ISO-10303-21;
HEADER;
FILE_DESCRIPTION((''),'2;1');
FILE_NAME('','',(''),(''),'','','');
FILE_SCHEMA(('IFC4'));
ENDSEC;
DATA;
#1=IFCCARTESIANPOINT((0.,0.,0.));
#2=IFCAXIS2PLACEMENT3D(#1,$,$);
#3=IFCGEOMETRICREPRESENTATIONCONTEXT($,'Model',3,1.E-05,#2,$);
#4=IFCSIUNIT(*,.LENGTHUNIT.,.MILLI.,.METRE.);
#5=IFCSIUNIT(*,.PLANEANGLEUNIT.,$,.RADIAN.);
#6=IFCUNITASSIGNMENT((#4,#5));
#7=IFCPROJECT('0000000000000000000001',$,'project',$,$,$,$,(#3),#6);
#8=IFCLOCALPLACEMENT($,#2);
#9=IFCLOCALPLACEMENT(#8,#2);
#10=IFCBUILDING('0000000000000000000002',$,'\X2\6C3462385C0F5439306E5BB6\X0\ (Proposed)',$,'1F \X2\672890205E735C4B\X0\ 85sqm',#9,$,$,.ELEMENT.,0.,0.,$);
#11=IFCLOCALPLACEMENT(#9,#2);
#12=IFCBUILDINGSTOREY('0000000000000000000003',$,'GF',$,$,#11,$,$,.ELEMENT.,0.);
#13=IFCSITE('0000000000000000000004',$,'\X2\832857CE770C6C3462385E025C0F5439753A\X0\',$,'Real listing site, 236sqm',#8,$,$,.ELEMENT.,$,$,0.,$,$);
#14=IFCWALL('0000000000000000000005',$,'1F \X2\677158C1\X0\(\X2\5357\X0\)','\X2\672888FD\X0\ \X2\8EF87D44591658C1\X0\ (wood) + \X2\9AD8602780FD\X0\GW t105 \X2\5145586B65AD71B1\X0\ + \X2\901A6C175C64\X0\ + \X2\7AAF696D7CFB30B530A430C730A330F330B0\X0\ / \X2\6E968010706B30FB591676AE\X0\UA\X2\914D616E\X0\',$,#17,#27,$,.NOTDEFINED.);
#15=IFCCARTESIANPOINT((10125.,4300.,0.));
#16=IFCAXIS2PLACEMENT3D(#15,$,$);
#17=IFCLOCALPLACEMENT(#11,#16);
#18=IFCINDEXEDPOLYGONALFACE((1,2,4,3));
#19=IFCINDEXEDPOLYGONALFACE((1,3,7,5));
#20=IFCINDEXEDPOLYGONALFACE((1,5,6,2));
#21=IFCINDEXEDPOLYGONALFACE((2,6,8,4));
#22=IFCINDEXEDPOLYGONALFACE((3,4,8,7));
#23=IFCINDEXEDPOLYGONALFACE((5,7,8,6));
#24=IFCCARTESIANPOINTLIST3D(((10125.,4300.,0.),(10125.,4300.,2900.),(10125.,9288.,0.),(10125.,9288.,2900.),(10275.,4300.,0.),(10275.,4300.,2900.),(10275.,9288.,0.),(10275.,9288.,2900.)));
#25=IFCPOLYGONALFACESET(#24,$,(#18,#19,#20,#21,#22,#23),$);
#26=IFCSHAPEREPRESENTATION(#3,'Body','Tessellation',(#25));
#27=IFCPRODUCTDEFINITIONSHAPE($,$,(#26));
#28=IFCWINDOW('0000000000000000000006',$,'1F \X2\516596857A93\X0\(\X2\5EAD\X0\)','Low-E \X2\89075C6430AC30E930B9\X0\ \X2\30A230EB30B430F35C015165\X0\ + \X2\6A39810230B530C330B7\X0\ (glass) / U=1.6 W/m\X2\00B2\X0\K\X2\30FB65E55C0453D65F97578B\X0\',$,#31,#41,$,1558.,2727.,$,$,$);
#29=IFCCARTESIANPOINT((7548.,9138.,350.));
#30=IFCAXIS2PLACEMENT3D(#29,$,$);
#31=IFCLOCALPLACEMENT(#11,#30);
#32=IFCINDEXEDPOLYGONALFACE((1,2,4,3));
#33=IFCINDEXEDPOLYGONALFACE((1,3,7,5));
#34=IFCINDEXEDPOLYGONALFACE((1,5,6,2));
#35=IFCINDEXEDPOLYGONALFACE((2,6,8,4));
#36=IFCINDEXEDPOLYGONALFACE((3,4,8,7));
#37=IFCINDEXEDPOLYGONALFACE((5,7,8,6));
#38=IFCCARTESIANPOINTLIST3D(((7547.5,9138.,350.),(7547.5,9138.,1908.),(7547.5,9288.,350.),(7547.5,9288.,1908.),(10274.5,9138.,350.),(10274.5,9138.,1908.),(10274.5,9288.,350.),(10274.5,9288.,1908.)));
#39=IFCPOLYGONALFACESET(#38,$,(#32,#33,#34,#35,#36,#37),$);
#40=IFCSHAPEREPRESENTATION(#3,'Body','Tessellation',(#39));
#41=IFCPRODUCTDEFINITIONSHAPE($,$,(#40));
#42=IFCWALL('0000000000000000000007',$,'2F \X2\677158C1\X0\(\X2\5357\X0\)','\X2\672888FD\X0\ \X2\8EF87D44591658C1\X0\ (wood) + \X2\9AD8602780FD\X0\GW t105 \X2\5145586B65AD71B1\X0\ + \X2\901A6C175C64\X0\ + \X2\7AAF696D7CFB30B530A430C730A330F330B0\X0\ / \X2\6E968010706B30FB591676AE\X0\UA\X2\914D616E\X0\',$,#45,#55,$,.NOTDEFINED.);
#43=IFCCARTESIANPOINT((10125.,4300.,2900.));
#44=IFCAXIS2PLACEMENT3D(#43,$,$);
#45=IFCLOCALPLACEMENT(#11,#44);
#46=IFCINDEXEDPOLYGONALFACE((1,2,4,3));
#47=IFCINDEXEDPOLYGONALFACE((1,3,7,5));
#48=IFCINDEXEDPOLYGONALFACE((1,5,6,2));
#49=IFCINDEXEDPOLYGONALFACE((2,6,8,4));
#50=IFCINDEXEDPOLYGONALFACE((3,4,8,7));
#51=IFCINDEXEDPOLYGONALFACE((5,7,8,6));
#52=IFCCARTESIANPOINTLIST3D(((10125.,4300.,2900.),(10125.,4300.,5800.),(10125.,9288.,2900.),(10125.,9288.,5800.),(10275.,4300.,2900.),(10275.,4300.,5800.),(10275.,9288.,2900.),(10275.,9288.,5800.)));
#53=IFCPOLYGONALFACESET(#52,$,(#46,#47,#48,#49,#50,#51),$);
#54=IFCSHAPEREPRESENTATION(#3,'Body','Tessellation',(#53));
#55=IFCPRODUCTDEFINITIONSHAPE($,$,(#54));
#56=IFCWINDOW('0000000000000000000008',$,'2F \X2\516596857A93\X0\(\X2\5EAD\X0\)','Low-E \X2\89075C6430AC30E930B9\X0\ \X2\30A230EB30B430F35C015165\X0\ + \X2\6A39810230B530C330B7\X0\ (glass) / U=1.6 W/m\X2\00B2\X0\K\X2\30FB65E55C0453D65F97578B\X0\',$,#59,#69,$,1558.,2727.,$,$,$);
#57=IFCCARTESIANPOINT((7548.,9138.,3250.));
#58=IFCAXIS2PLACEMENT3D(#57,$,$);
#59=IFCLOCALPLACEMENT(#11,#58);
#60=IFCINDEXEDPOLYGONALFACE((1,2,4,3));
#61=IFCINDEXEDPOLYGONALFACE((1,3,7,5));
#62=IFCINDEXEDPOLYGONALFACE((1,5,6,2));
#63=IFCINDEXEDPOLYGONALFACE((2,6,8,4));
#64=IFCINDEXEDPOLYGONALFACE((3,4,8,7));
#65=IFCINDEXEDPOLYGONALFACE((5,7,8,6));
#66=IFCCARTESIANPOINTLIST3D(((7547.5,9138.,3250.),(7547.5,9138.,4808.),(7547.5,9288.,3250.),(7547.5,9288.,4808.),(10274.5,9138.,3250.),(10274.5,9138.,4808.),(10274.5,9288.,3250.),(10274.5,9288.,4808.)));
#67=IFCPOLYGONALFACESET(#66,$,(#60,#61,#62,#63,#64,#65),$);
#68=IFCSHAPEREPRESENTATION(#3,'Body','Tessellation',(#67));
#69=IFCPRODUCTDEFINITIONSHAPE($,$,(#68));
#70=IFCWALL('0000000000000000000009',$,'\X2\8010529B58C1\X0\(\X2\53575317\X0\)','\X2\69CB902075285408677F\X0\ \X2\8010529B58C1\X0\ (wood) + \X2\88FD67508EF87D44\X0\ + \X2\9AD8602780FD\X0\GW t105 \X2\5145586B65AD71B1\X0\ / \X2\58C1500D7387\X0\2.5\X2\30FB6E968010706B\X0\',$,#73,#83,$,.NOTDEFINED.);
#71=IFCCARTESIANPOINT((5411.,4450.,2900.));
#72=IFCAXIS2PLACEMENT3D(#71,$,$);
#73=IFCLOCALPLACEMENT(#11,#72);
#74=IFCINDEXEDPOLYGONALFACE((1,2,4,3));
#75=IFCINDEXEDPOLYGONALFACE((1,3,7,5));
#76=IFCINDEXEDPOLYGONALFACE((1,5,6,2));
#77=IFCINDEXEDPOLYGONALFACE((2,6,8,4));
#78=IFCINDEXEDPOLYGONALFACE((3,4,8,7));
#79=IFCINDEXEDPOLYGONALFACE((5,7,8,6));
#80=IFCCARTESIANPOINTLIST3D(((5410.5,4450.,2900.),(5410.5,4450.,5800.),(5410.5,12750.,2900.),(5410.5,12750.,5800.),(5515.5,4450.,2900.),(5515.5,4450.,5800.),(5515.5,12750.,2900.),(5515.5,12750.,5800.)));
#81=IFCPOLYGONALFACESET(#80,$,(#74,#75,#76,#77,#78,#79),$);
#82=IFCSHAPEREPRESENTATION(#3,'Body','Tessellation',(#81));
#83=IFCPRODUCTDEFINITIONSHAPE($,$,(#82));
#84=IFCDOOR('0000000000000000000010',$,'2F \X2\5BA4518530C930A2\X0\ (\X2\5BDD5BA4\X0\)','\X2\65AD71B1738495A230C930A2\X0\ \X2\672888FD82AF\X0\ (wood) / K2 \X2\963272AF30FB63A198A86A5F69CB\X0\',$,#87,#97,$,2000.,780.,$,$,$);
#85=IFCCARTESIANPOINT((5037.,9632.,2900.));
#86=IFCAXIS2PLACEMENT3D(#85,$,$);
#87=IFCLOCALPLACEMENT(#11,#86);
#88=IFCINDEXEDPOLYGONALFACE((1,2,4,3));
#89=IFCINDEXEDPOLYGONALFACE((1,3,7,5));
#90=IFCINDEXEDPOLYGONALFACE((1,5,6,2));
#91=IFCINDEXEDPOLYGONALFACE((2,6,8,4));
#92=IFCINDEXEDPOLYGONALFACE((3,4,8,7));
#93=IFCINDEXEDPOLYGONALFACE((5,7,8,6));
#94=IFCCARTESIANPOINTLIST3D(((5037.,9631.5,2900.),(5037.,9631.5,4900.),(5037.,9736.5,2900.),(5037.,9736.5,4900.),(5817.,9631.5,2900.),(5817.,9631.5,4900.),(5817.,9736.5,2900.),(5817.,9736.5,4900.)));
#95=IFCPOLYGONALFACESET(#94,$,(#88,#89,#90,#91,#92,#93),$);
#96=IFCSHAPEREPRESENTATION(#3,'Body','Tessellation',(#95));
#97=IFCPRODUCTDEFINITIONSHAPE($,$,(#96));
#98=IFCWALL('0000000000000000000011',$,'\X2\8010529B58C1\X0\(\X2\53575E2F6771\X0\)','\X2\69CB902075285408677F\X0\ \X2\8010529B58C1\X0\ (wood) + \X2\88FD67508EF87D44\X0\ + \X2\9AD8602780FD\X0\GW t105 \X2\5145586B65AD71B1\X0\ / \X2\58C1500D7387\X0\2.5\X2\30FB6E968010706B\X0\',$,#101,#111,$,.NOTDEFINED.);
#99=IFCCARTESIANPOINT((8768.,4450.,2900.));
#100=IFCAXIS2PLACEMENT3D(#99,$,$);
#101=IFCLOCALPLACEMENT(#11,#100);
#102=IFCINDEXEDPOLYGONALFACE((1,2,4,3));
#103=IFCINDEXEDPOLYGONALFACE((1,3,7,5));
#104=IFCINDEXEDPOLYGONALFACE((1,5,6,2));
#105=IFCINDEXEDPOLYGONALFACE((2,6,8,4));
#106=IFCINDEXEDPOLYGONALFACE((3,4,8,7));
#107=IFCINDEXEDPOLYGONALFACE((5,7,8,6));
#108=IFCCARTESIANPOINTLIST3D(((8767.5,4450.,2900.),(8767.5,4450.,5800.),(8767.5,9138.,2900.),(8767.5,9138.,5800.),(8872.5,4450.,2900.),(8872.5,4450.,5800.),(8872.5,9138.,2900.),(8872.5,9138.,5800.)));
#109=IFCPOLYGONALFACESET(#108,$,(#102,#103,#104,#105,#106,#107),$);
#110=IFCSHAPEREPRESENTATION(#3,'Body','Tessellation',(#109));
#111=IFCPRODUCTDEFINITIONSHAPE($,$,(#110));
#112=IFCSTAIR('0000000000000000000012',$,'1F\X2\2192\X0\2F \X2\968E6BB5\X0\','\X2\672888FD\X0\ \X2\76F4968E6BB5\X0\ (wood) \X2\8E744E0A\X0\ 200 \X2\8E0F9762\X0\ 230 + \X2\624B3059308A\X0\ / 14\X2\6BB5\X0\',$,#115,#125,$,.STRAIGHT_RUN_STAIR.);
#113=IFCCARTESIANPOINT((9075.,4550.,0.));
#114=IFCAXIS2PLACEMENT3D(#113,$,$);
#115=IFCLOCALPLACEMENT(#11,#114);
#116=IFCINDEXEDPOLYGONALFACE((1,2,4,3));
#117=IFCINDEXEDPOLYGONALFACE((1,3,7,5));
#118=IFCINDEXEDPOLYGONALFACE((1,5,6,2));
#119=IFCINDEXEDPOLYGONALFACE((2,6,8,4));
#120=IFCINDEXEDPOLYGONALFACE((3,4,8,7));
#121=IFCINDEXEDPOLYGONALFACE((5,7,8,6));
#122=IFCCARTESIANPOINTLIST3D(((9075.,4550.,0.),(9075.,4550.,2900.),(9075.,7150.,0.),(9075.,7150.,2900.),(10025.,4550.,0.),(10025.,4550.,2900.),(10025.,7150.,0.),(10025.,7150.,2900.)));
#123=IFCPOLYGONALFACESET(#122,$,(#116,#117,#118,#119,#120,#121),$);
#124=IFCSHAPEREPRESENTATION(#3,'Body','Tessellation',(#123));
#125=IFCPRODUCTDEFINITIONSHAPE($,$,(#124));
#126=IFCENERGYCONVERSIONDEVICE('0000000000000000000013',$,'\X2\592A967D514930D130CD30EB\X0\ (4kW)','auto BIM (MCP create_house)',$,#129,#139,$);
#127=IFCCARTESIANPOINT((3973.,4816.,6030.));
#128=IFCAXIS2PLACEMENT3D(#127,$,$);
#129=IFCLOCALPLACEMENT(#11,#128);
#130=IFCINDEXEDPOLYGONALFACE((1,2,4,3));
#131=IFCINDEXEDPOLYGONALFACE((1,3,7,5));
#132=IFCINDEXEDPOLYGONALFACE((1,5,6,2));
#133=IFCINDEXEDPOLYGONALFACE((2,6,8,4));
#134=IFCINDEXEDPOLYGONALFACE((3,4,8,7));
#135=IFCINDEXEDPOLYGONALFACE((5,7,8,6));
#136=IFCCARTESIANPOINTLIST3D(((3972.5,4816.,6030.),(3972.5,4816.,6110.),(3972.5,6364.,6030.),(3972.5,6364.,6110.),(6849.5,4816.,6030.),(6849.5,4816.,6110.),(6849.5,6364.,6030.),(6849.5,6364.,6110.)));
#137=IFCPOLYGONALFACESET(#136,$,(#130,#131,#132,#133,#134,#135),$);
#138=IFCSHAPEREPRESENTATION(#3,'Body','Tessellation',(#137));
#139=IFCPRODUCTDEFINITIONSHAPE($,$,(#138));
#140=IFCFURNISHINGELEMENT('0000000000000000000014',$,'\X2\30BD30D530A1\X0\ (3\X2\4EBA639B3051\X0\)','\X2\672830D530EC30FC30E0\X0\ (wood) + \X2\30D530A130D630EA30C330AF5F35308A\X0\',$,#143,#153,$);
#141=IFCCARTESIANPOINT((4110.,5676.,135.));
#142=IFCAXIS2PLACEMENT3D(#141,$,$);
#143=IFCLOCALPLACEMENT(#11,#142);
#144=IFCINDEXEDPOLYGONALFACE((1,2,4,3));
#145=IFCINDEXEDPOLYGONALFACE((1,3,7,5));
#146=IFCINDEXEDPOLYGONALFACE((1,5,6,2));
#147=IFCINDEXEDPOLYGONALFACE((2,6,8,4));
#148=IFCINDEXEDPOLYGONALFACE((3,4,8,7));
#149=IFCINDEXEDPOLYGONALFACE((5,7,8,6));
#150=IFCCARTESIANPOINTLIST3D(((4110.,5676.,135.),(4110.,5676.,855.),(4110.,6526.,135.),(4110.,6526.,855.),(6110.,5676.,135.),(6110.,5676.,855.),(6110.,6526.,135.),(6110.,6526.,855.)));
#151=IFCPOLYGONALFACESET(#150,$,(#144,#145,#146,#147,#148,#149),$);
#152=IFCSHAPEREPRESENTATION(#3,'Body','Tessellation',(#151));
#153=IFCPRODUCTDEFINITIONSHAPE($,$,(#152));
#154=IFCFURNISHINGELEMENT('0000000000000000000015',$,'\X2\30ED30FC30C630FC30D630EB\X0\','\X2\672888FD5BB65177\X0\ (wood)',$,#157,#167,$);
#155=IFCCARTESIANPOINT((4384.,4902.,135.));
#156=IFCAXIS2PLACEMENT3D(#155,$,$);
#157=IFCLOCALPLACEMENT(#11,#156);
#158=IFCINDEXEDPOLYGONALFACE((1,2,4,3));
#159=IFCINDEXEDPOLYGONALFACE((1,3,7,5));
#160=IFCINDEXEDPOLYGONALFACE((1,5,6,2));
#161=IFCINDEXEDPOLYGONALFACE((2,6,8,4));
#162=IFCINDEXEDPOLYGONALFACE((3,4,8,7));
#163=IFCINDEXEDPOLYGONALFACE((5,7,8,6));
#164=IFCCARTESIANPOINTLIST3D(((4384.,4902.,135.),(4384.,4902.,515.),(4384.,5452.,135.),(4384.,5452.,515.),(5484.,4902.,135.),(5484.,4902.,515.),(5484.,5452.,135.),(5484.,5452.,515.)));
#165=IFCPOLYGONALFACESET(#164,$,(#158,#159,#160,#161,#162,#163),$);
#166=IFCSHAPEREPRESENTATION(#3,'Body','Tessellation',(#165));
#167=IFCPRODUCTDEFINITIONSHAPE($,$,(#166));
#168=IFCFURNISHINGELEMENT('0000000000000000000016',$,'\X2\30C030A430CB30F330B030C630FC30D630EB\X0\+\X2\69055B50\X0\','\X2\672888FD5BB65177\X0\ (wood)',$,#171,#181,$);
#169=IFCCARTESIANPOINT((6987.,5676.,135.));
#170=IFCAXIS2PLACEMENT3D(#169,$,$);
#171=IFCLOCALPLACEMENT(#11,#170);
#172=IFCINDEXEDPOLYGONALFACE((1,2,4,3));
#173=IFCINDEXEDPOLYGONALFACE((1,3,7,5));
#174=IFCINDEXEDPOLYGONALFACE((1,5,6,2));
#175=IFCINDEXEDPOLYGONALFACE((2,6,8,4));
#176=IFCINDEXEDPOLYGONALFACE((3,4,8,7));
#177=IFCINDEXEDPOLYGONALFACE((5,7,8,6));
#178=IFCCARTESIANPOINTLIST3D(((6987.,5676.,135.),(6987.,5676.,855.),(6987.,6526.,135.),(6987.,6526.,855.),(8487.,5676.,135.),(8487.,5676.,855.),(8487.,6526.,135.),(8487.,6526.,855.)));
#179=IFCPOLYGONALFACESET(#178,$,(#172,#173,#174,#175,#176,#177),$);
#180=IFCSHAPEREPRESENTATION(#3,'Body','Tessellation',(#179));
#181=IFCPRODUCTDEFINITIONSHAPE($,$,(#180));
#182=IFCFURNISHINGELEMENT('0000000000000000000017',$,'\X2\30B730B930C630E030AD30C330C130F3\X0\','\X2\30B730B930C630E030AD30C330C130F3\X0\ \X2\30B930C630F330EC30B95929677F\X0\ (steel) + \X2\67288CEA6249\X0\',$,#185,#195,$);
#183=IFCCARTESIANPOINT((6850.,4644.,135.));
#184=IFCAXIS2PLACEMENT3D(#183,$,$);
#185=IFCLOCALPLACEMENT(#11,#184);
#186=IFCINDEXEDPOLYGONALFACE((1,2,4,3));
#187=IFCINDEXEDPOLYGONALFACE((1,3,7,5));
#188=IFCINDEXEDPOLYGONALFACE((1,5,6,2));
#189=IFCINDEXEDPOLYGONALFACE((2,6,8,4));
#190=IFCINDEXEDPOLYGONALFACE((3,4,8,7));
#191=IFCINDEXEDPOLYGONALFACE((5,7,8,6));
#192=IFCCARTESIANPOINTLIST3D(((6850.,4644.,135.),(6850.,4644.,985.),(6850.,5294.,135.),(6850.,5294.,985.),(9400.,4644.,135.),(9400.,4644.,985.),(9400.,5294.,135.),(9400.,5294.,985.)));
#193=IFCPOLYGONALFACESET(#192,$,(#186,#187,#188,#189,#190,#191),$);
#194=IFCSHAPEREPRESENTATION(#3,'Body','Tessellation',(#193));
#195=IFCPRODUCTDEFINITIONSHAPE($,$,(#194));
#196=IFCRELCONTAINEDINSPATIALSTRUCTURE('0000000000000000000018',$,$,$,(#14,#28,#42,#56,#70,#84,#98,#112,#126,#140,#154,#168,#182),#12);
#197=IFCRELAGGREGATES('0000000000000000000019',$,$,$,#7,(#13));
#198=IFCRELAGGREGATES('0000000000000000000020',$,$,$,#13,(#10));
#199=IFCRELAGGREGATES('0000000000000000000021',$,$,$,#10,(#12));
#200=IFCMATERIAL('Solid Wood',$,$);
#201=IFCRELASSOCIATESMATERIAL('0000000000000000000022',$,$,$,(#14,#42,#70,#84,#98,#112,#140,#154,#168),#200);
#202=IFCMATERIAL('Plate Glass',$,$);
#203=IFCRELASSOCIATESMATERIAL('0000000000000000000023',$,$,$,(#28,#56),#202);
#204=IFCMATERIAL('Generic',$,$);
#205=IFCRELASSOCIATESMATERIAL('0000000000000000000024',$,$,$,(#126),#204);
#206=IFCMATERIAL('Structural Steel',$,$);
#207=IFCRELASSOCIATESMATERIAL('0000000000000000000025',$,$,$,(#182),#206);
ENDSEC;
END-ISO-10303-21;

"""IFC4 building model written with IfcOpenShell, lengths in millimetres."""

from ifc_helpers import new_model, si_unit, frame, frame_2d, origin, place, context, project, spatial, rectangle, extrude, material, element, fill, save


model = new_model("IFC4")

# Units and contexts
model_context = context("Model", 3, precision=1e-05, world=origin())
ifc_project = project(units=[si_unit("LENGTHUNIT", "METRE", prefix="MILLI"), si_unit("PLANEANGLEUNIT", "RADIAN")], contexts=[model_context])

# Site, building, storey
site_placement = place(None, origin())
site = spatial("IfcSite", under=ifc_project, at=site_placement, Name="茨城県水戸市小吹町", ObjectType="Real listing site, 236sqm", CompositionType="ELEMENT", RefElevation=0.0)
building_placement = place(site_placement, origin())
building = spatial("IfcBuilding", under=site, at=building_placement, Name="水戸小吹の家 (Proposed)", ObjectType="1F 木造平屋 85sqm", CompositionType="ELEMENT", ElevationOfRefHeight=0.0, ElevationOfTerrain=0.0)
storey_placement = place(building_placement, origin())
storey = spatial("IfcBuildingStorey", under=building, at=storey_placement, Name="GF", CompositionType="ELEMENT", Elevation=0.0)

# Wall, opening, window
ifc_material_1 = material(Name="Solid Wood")
wall_1_placement = place(storey_placement, frame((10125.0, 4300.0, 0.0)))
wall_1 = element("IfcWall", 1, at=wall_1_placement, inside=storey, material=ifc_material_1, Name="1F 東壁(南)", Description="木製 軸組外壁 (wood) + 高性能GW t105 充填断熱 + 通気層 + 窯業系サイディング / 準耐火・外皮UA配慮", PredefinedType="NOTDEFINED", context=model_context, shape_type="SweptSolid", body=[
    extrude(rectangle(XDim=150.0, YDim=4988.0, at=frame_2d((75.0, 2494.0))), frame((10125.0, 4300.0, 0.0)), (0.0, 0.0, 1.0), 2900.0),
])
opening_1_placement = place(storey_placement, frame((7548.0, 9138.0, 350.0)))
opening_1 = element("IfcOpeningElement", 2, at=opening_1_placement, cuts=wall_1, PredefinedType="NOTDEFINED", context=model_context, shape_type="SweptSolid", body=[
    extrude(rectangle(XDim=2727.0, YDim=150.0, at=frame_2d((1363.0, 75.0))), frame((7548.0, 9138.0, 350.0)), (0.0, 0.0, 1.0), 1558.0),
])
ifc_material_2 = material(Name="Plate Glass")
window_1_placement = place(storey_placement, frame((7548.0, 9138.0, 350.0)))
window_1 = element("IfcWindow", 3, at=window_1_placement, inside=storey, material=ifc_material_2, Name="1F 入隅窓(庭)", Description="Low-E 複層ガラス アルゴン封入 + 樹脂サッシ (glass) / U=1.6 W/m²K・日射取得型", OverallHeight=1558.0, OverallWidth=2727.0, context=model_context, shape_type="SweptSolid", body=[
    extrude(rectangle(XDim=2727.0, YDim=150.0, at=frame_2d((1363.0, 75.0))), frame((7548.0, 9138.0, 350.0)), (0.0, 0.0, 1.0), 1558.0),
])
fill(opening_1, window_1)

# Wall, opening, window
wall_2_placement = place(storey_placement, frame((10125.0, 4300.0, 2900.0)))
wall_2 = element("IfcWall", 4, at=wall_2_placement, inside=storey, material=ifc_material_1, Name="2F 東壁(南)", Description="木製 軸組外壁 (wood) + 高性能GW t105 充填断熱 + 通気層 + 窯業系サイディング / 準耐火・外皮UA配慮", PredefinedType="NOTDEFINED", context=model_context, shape_type="SweptSolid", body=[
    extrude(rectangle(XDim=150.0, YDim=4988.0, at=frame_2d((75.0, 2494.0))), frame((10125.0, 4300.0, 2900.0)), (0.0, 0.0, 1.0), 2900.0),
])
opening_2_placement = place(storey_placement, frame((7548.0, 9138.0, 3250.0)))
opening_2 = element("IfcOpeningElement", 5, at=opening_2_placement, cuts=wall_2, PredefinedType="NOTDEFINED", context=model_context, shape_type="SweptSolid", body=[
    extrude(rectangle(XDim=2727.0, YDim=150.0, at=frame_2d((1363.0, 75.0))), frame((7548.0, 9138.0, 3250.0)), (0.0, 0.0, 1.0), 1558.0),
])
window_2_placement = place(storey_placement, frame((7548.0, 9138.0, 3250.0)))
window_2 = element("IfcWindow", 6, at=window_2_placement, inside=storey, material=ifc_material_2, Name="2F 入隅窓(庭)", Description="Low-E 複層ガラス アルゴン封入 + 樹脂サッシ (glass) / U=1.6 W/m²K・日射取得型", OverallHeight=1558.0, OverallWidth=2727.0, context=model_context, shape_type="SweptSolid", body=[
    extrude(rectangle(XDim=2727.0, YDim=150.0, at=frame_2d((1363.0, 75.0))), frame((7548.0, 9138.0, 3250.0)), (0.0, 0.0, 1.0), 1558.0),
])
fill(opening_2, window_2)

# Wall, opening, door
wall_3_placement = place(storey_placement, frame((5411.0, 4450.0, 2900.0)))
wall_3 = element("IfcWall", 7, at=wall_3_placement, inside=storey, material=ifc_material_1, Name="耐力壁(南北)", Description="構造用合板 耐力壁 (wood) + 製材軸組 + 高性能GW t105 充填断熱 / 壁倍率2.5・準耐火", PredefinedType="NOTDEFINED", context=model_context, shape_type="SweptSolid", body=[
    extrude(rectangle(XDim=105.0, YDim=8300.0, at=frame_2d((52.0, 4150.0))), frame((5411.0, 4450.0, 2900.0)), (0.0, 0.0, 1.0), 2900.0),
])
opening_3_placement = place(storey_placement, frame((5037.0, 9632.0, 2900.0)))
opening_3 = element("IfcOpeningElement", 8, at=opening_3_placement, cuts=wall_3, PredefinedType="NOTDEFINED", context=model_context, shape_type="SweptSolid", body=[
    extrude(rectangle(XDim=780.0, YDim=105.0, at=frame_2d((390.0, 52.0))), frame((5037.0, 9632.0, 2900.0)), (0.0, 0.0, 1.0), 2000.0),
])
door_1_placement = place(storey_placement, frame((5037.0, 9632.0, 2900.0)))
door_1 = element("IfcDoor", 9, at=door_1_placement, inside=storey, material=ifc_material_1, Name="2F 室内ドア (寝室)", Description="断熱玄関ドア 木製芯 (wood) / K2 防犯・採風機構", OverallHeight=2000.0, OverallWidth=780.0, context=model_context, shape_type="SweptSolid", body=[
    extrude(rectangle(XDim=780.0, YDim=105.0, at=frame_2d((390.0, 52.0))), frame((5037.0, 9632.0, 2900.0)), (0.0, 0.0, 1.0), 2000.0),
])
fill(opening_3, door_1)

# Wall
wall_4_placement = place(storey_placement, frame((8768.0, 4450.0, 2900.0)))
element("IfcWall", 10, at=wall_4_placement, inside=storey, material=ifc_material_1, Name="耐力壁(南帯東)", Description="構造用合板 耐力壁 (wood) + 製材軸組 + 高性能GW t105 充填断熱 / 壁倍率2.5・準耐火", PredefinedType="NOTDEFINED", context=model_context, shape_type="SweptSolid", body=[
    extrude(rectangle(XDim=105.0, YDim=4688.0, at=frame_2d((52.0, 2344.0))), frame((8768.0, 4450.0, 2900.0)), (0.0, 0.0, 1.0), 2900.0),
])

# Stair
stair_placement = place(storey_placement, frame((9075.0, 4550.0, 0.0)))
element("IfcStair", 11, at=stair_placement, inside=storey, material=ifc_material_1, Name="1F→2F 階段", Description="木製 直階段 (wood) 蹴上 200 踏面 230 + 手すり / 14段", PredefinedType="STRAIGHT_RUN_STAIR", context=model_context, shape_type="SweptSolid", body=[
    extrude(rectangle(XDim=950.0, YDim=2600.0, at=frame_2d((475.0, 1300.0))), frame((9075.0, 4550.0, 0.0)), (0.0, 0.0, 1.0), 2900.0),
])

# Energy conversion device
ifc_material_3 = material(Name="Generic")
energy_conversion_device_placement = place(storey_placement, frame((3973.0, 4816.0, 6030.0)))
element("IfcEnergyConversionDevice", 12, at=energy_conversion_device_placement, inside=storey, material=ifc_material_3, Name="太陽光パネル (4kW)", Description="auto BIM (MCP create_house)", context=model_context, shape_type="SweptSolid", body=[
    extrude(rectangle(XDim=2877.0, YDim=1548.0, at=frame_2d((1438.0, 774.0))), frame((3973.0, 4816.0, 6030.0)), (0.0, 0.0, 1.0), 80.0),
])

# Furnishing elements
furnishing_1_placement = place(storey_placement, frame((4110.0, 5676.0, 135.0)))
element("IfcFurnishingElement", 13, at=furnishing_1_placement, inside=storey, material=ifc_material_1, Name="ソファ (3人掛け)", Description="木フレーム (wood) + ファブリック張り", context=model_context, shape_type="SweptSolid", body=[
    extrude(rectangle(XDim=2000.0, YDim=850.0, at=frame_2d((1000.0, 425.0))), frame((4110.0, 5676.0, 135.0)), (0.0, 0.0, 1.0), 720.0),
])
furnishing_2_placement = place(storey_placement, frame((4384.0, 4902.0, 135.0)))
element("IfcFurnishingElement", 14, at=furnishing_2_placement, inside=storey, material=ifc_material_1, Name="ローテーブル", Description="木製家具 (wood)", context=model_context, shape_type="SweptSolid", body=[
    extrude(rectangle(XDim=1100.0, YDim=550.0, at=frame_2d((550.0, 275.0))), frame((4384.0, 4902.0, 135.0)), (0.0, 0.0, 1.0), 380.0),
])
furnishing_3_placement = place(storey_placement, frame((6987.0, 5676.0, 135.0)))
element("IfcFurnishingElement", 15, at=furnishing_3_placement, inside=storey, material=ifc_material_1, Name="ダイニングテーブル+椅子", Description="木製家具 (wood)", context=model_context, shape_type="SweptSolid", body=[
    extrude(rectangle(XDim=1500.0, YDim=850.0, at=frame_2d((750.0, 425.0))), frame((6987.0, 5676.0, 135.0)), (0.0, 0.0, 1.0), 720.0),
])
ifc_material_4 = material(Name="Structural Steel")
furnishing_4_placement = place(storey_placement, frame((6850.0, 4644.0, 135.0)))
element("IfcFurnishingElement", 16, at=furnishing_4_placement, inside=storey, material=ifc_material_4, Name="システムキッチン", Description="システムキッチン ステンレス天板 (steel) + 木質扉", context=model_context, shape_type="SweptSolid", body=[
    extrude(rectangle(XDim=2550.0, YDim=650.0, at=frame_2d((1275.0, 325.0))), frame((6850.0, 4644.0, 135.0)), (0.0, 0.0, 1.0), 850.0),
])

save(model, "model.ifc")
